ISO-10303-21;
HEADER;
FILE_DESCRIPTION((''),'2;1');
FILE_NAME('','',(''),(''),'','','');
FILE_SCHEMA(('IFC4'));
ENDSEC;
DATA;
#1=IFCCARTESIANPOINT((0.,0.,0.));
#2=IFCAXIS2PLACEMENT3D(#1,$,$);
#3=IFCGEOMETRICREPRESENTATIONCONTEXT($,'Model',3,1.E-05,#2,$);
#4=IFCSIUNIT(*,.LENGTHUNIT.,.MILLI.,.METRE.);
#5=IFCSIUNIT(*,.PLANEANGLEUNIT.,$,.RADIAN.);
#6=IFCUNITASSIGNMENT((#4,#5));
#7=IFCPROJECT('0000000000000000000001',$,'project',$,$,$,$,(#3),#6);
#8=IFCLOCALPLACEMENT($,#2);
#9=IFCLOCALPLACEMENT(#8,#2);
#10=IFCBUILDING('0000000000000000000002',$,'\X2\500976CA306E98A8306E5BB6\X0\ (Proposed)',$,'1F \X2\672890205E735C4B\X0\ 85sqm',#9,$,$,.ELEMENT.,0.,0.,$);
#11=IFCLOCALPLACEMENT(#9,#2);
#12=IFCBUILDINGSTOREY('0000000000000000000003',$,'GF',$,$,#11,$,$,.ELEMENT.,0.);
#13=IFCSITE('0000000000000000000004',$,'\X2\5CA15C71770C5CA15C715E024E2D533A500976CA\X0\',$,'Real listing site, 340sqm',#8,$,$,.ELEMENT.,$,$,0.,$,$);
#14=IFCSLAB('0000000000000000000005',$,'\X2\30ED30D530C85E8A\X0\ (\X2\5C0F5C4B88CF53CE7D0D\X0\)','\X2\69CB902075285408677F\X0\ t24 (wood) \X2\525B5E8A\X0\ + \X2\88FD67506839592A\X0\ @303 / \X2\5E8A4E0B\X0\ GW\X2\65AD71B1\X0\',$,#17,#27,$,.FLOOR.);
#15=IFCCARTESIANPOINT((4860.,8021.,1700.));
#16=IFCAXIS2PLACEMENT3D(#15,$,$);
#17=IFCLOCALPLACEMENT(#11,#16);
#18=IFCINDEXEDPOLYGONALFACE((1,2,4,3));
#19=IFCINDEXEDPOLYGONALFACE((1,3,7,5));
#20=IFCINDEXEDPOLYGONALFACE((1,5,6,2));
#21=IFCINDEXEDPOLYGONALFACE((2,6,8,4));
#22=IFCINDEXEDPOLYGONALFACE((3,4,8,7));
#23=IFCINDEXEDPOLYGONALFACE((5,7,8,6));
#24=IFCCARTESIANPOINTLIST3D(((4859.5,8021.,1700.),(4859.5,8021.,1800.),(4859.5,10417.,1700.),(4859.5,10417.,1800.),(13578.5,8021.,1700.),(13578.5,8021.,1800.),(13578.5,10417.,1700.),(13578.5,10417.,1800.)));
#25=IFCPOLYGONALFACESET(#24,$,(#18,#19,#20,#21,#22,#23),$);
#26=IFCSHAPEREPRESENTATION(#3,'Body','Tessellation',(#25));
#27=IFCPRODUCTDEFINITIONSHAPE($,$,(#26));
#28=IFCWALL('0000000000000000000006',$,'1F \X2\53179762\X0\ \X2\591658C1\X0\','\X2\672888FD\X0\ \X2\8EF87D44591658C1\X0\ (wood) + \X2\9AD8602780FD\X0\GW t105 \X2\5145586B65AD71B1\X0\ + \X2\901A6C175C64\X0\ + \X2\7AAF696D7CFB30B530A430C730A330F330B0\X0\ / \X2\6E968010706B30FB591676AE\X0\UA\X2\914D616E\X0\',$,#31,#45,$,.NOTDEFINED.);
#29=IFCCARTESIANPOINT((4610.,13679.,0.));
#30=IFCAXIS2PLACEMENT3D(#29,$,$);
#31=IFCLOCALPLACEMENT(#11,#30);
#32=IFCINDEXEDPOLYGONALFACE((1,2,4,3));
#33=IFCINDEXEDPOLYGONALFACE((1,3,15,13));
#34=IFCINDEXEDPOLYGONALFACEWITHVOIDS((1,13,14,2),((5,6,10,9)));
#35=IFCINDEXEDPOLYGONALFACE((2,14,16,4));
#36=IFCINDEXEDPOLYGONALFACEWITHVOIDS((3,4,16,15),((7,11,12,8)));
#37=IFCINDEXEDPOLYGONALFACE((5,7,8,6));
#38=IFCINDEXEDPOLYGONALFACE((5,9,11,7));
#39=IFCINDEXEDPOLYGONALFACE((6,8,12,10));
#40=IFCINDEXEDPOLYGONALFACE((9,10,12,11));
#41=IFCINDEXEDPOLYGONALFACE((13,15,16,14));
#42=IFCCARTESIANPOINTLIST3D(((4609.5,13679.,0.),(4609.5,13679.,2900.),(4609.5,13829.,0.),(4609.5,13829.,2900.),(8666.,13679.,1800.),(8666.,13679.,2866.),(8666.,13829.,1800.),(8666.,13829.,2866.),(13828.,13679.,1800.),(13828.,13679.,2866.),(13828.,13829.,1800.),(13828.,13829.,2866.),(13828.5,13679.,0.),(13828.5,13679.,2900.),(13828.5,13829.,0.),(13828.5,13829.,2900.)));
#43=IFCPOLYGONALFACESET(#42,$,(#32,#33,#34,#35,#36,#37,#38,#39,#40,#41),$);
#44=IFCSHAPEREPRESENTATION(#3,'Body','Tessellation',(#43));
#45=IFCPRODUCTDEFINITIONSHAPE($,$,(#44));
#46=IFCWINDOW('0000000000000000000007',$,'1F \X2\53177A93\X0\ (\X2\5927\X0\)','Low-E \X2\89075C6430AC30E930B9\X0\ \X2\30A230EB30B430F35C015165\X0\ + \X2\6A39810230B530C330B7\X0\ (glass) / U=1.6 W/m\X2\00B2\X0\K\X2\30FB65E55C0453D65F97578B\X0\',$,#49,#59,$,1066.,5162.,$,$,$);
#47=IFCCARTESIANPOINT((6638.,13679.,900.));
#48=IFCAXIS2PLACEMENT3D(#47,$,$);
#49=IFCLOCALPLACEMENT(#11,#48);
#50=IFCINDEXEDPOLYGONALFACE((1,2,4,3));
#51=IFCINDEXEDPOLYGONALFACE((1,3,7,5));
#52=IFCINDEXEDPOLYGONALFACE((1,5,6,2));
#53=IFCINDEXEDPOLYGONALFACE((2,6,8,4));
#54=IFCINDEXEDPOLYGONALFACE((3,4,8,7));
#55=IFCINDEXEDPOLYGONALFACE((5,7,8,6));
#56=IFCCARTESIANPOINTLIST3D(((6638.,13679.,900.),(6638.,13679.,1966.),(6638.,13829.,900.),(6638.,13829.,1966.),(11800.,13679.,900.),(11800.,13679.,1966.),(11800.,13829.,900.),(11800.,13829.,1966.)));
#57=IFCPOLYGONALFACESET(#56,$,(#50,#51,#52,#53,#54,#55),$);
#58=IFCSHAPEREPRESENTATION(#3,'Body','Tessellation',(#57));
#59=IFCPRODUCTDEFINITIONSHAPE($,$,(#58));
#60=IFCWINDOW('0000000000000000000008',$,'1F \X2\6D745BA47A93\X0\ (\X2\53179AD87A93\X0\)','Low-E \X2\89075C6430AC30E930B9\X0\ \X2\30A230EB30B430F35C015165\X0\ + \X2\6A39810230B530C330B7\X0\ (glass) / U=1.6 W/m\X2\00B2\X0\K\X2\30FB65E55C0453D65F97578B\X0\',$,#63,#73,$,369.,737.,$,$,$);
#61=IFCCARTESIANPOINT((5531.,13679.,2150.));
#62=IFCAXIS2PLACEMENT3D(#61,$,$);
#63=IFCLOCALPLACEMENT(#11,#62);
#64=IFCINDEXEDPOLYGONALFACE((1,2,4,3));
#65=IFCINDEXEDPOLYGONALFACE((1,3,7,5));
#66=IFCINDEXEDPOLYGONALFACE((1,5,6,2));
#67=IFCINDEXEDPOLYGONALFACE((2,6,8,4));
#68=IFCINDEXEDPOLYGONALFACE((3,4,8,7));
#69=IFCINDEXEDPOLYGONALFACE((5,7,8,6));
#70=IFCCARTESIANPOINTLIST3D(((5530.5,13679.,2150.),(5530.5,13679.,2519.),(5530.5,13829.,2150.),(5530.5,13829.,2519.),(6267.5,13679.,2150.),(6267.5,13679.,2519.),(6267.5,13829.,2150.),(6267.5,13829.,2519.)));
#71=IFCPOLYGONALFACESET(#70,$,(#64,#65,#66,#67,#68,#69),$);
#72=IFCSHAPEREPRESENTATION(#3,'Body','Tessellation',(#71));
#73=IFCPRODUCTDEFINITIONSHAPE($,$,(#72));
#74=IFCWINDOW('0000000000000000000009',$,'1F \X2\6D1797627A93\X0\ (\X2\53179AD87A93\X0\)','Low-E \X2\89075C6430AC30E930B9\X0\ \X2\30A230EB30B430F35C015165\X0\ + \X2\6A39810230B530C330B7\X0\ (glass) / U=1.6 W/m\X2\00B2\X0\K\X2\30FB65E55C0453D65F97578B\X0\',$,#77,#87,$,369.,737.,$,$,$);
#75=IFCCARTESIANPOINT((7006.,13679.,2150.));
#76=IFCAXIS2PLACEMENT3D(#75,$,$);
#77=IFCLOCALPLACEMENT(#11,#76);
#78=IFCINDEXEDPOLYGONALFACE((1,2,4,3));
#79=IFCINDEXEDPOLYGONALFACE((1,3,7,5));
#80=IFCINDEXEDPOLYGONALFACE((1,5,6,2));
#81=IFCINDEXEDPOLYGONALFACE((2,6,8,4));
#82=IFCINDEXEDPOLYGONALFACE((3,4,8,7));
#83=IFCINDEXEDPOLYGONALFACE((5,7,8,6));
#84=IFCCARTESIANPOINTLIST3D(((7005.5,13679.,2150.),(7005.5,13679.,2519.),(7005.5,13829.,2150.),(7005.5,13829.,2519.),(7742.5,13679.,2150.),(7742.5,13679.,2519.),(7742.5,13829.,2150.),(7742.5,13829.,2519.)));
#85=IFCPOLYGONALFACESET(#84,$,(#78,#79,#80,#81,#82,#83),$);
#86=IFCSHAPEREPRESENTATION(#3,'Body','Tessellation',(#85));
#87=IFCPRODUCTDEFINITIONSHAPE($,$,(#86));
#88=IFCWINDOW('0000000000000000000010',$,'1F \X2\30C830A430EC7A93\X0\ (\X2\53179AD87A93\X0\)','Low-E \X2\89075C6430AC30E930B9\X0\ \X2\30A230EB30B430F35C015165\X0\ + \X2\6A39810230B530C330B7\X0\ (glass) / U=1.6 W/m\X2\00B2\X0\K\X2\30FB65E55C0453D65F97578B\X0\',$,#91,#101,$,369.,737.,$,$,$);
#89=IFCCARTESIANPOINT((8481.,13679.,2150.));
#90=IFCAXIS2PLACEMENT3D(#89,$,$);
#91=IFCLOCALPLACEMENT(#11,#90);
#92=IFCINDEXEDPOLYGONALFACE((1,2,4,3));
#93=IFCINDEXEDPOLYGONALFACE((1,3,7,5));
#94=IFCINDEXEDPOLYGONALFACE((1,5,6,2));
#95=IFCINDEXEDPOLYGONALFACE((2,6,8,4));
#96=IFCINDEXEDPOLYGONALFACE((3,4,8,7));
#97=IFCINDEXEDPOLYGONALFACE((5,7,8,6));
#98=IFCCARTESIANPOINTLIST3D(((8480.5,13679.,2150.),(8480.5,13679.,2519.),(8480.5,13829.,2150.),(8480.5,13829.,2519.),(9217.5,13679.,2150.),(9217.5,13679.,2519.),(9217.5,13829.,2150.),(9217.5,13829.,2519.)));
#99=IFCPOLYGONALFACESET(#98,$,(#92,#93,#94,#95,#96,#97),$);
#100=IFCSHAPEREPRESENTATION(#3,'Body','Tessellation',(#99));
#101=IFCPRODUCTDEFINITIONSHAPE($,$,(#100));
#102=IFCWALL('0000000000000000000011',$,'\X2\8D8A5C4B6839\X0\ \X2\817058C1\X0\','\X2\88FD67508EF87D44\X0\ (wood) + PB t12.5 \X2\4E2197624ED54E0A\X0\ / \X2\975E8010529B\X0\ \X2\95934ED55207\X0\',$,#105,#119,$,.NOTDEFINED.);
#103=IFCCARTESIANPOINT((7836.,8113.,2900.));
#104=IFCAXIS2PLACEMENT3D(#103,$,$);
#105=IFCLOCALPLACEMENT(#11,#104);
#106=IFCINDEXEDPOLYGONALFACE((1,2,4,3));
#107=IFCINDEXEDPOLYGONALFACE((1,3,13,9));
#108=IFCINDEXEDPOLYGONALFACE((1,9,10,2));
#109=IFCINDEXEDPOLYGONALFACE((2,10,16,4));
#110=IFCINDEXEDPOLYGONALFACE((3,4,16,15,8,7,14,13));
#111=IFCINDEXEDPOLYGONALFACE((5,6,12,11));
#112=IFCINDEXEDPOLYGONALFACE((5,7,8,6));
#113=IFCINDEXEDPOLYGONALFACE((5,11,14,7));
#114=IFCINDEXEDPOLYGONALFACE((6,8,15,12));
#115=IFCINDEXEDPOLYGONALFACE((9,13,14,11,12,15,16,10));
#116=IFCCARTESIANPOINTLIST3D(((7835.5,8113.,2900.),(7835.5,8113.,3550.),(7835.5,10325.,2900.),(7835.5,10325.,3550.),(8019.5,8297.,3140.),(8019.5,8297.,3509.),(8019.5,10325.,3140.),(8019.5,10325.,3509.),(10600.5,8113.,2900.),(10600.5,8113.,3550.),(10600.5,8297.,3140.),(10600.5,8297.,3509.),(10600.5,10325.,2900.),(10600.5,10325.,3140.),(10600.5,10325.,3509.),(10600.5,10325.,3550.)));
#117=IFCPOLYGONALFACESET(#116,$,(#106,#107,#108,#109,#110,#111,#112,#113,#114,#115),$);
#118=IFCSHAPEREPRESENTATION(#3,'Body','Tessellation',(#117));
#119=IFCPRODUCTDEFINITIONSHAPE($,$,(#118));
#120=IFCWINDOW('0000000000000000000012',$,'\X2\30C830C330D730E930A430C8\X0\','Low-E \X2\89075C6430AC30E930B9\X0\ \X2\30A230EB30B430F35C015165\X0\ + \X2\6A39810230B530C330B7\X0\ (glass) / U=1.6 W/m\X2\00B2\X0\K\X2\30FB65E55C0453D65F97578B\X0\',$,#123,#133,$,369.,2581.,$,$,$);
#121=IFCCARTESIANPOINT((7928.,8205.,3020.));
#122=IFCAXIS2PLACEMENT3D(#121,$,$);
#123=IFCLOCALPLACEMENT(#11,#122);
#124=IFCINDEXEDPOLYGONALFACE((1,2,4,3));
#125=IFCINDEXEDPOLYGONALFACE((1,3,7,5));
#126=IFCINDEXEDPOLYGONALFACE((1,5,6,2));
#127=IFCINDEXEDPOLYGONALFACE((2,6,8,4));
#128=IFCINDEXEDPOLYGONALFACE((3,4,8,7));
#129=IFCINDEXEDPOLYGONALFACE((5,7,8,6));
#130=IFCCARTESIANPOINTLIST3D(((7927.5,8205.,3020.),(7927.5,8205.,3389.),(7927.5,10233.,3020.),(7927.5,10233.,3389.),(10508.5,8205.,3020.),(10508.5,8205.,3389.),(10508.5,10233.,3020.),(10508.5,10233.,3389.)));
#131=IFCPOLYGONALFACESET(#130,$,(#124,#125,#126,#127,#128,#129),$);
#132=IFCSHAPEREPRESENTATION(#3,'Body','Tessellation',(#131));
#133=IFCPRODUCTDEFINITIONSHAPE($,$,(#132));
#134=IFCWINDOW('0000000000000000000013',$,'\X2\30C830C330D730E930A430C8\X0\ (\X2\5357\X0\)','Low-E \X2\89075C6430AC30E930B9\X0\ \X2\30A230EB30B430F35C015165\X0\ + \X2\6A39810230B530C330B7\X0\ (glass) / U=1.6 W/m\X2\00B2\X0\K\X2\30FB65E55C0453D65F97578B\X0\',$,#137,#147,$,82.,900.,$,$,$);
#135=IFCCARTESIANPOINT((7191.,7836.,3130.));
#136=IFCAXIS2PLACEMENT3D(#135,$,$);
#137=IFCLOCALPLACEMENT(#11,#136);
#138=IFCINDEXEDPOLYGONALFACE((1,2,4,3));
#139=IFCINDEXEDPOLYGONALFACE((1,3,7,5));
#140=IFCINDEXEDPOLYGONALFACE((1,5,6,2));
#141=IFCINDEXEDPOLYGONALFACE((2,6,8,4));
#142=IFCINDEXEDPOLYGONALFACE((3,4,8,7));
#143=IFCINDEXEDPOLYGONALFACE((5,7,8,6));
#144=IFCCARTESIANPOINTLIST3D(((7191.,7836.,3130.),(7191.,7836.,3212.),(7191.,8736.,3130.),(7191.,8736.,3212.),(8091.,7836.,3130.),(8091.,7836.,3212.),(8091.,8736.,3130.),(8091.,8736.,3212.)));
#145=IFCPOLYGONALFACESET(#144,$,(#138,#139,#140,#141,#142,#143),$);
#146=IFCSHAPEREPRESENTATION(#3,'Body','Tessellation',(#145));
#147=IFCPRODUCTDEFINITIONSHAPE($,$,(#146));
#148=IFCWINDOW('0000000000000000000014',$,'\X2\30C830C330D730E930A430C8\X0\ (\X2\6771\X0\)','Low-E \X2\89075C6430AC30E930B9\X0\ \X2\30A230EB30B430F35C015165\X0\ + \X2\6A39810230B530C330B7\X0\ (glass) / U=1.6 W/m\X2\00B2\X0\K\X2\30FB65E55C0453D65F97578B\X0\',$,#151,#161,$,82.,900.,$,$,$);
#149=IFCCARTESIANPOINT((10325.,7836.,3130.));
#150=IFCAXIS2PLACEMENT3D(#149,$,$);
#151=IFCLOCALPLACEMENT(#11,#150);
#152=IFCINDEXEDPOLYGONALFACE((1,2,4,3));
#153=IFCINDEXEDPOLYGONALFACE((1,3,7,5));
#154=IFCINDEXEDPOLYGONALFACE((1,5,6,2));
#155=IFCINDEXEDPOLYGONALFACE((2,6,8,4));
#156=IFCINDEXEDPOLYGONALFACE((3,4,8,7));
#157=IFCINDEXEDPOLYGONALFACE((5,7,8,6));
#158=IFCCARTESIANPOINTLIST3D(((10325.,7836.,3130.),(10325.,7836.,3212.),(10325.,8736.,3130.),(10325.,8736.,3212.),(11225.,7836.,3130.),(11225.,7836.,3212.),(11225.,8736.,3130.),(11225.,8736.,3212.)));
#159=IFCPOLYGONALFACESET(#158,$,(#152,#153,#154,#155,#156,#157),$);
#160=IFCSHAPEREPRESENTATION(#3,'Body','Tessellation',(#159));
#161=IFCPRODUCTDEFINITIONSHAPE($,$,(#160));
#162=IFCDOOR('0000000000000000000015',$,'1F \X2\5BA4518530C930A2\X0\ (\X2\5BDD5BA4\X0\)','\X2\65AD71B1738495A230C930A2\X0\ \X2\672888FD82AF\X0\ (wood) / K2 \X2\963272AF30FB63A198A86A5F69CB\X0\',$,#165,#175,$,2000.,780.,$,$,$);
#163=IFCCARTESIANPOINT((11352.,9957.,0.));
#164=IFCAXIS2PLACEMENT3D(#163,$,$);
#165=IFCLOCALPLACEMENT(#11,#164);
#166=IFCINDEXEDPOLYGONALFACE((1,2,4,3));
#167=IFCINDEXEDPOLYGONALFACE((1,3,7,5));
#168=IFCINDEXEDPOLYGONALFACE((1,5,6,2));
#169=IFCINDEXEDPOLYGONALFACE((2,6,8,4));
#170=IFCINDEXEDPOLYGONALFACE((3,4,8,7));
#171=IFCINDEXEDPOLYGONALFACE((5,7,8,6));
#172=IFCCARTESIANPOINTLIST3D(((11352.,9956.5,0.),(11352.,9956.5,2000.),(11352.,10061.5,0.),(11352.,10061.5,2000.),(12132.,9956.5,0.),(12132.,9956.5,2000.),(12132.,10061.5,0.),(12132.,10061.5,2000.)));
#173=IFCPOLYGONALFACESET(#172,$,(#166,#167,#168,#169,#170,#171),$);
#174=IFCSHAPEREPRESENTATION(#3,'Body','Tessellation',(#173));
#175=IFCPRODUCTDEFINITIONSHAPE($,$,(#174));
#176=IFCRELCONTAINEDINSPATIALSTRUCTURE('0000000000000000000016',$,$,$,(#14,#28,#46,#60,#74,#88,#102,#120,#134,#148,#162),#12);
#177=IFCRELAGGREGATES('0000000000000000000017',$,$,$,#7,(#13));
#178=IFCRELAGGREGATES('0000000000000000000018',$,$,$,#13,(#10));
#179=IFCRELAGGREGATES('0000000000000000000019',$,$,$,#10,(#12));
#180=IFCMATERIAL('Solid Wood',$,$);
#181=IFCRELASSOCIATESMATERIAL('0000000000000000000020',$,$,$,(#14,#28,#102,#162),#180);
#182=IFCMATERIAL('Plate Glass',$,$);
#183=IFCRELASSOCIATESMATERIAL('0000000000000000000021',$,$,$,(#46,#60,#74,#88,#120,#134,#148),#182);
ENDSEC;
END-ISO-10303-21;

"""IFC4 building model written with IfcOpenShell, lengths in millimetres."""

from ifc_helpers import new_model, si_unit, frame, frame_2d, origin, place, context, project, spatial, rectangle, extrude, material, element, fill, save


model = new_model("IFC4")

# Units and contexts
model_context = context("Model", 3, precision=1e-05, world=origin())
ifc_project = project(units=[si_unit("LENGTHUNIT", "METRE", prefix="MILLI"), si_unit("PLANEANGLEUNIT", "RADIAN")], contexts=[model_context])

# Site, building, storey
site_placement = place(None, origin())
site = spatial("IfcSite", under=ifc_project, at=site_placement, Name="岡山県岡山市中区倉益", ObjectType="Real listing site, 340sqm", CompositionType="ELEMENT", RefElevation=0.0)
building_placement = place(site_placement, origin())
building = spatial("IfcBuilding", under=site, at=building_placement, Name="倉益の風の家 (Proposed)", ObjectType="1F 木造平屋 85sqm", CompositionType="ELEMENT", ElevationOfRefHeight=0.0, ElevationOfTerrain=0.0)
storey_placement = place(building_placement, origin())
storey = spatial("IfcBuildingStorey", under=building, at=storey_placement, Name="GF", CompositionType="ELEMENT", Elevation=0.0)

# Slab
ifc_material_1 = material(Name="Solid Wood")
slab_placement = place(storey_placement, frame((4860.0, 8021.0, 1700.0)))
element("IfcSlab", 1, at=slab_placement, inside=storey, material=ifc_material_1, Name="ロフト床 (小屋裏収納)", Description="構造用合板 t24 (wood) 剛床 + 製材根太 @303 / 床下 GW断熱", PredefinedType="FLOOR", context=model_context, shape_type="SweptSolid", body=[
    extrude(rectangle(XDim=8719.0, YDim=2396.0, at=frame_2d((4359.0, 1198.0))), frame((4860.0, 8021.0, 1700.0)), (0.0, 0.0, 1.0), 100.0),
])

# Wall, openings, windows
wall_1_placement = place(storey_placement, frame((4610.0, 13679.0, 0.0)))
wall_1 = element("IfcWall", 2, at=wall_1_placement, inside=storey, material=ifc_material_1, Name="1F 北面 外壁", Description="木製 軸組外壁 (wood) + 高性能GW t105 充填断熱 + 通気層 + 窯業系サイディング / 準耐火・外皮UA配慮", PredefinedType="NOTDEFINED", context=model_context, shape_type="SweptSolid", body=[
    extrude(rectangle(XDim=9219.0, YDim=150.0, at=frame_2d((4609.0, 75.0))), frame((4610.0, 13679.0, 0.0)), (0.0, 0.0, 1.0), 2900.0),
])
opening_1_placement = place(storey_placement, frame((6638.0, 13679.0, 900.0)))
opening_1 = element("IfcOpeningElement", 3, at=opening_1_placement, cuts=wall_1, PredefinedType="NOTDEFINED", context=model_context, shape_type="SweptSolid", body=[
    extrude(rectangle(XDim=5162.0, YDim=150.0, at=frame_2d((2581.0, 75.0))), frame((6638.0, 13679.0, 900.0)), (0.0, 0.0, 1.0), 1066.0),
])
opening_2_placement = place(storey_placement, frame((5531.0, 13679.0, 2150.0)))
opening_2 = element("IfcOpeningElement", 4, at=opening_2_placement, cuts=wall_1, PredefinedType="NOTDEFINED", context=model_context, shape_type="SweptSolid", body=[
    extrude(rectangle(XDim=737.0, YDim=150.0, at=frame_2d((368.0, 75.0))), frame((5531.0, 13679.0, 2150.0)), (0.0, 0.0, 1.0), 369.0),
])
opening_3_placement = place(storey_placement, frame((7006.0, 13679.0, 2150.0)))
opening_3 = element("IfcOpeningElement", 5, at=opening_3_placement, cuts=wall_1, PredefinedType="NOTDEFINED", context=model_context, shape_type="SweptSolid", body=[
    extrude(rectangle(XDim=737.0, YDim=150.0, at=frame_2d((368.0, 75.0))), frame((7006.0, 13679.0, 2150.0)), (0.0, 0.0, 1.0), 369.0),
])
opening_4_placement = place(storey_placement, frame((8481.0, 13679.0, 2150.0)))
opening_4 = element("IfcOpeningElement", 6, at=opening_4_placement, cuts=wall_1, PredefinedType="NOTDEFINED", context=model_context, shape_type="SweptSolid", body=[
    extrude(rectangle(XDim=737.0, YDim=150.0, at=frame_2d((368.0, 75.0))), frame((8481.0, 13679.0, 2150.0)), (0.0, 0.0, 1.0), 369.0),
])
ifc_material_2 = material(Name="Plate Glass")
window_1_placement = place(storey_placement, frame((6638.0, 13679.0, 900.0)))
window_1 = element("IfcWindow", 7, at=window_1_placement, inside=storey, material=ifc_material_2, Name="1F 北窓 (大)", Description="Low-E 複層ガラス アルゴン封入 + 樹脂サッシ (glass) / U=1.6 W/m²K・日射取得型", OverallHeight=1066.0, OverallWidth=5162.0, context=model_context, shape_type="SweptSolid", body=[
    extrude(rectangle(XDim=5162.0, YDim=150.0, at=frame_2d((2581.0, 75.0))), frame((6638.0, 13679.0, 900.0)), (0.0, 0.0, 1.0), 1066.0),
])
fill(opening_1, window_1)
window_2_placement = place(storey_placement, frame((5531.0, 13679.0, 2150.0)))
window_2 = element("IfcWindow", 8, at=window_2_placement, inside=storey, material=ifc_material_2, Name="1F 浴室窓 (北高窓)", Description="Low-E 複層ガラス アルゴン封入 + 樹脂サッシ (glass) / U=1.6 W/m²K・日射取得型", OverallHeight=369.0, OverallWidth=737.0, context=model_context, shape_type="SweptSolid", body=[
    extrude(rectangle(XDim=737.0, YDim=150.0, at=frame_2d((368.0, 75.0))), frame((5531.0, 13679.0, 2150.0)), (0.0, 0.0, 1.0), 369.0),
])
fill(opening_2, window_2)
window_3_placement = place(storey_placement, frame((7006.0, 13679.0, 2150.0)))
window_3 = element("IfcWindow", 9, at=window_3_placement, inside=storey, material=ifc_material_2, Name="1F 洗面窓 (北高窓)", Description="Low-E 複層ガラス アルゴン封入 + 樹脂サッシ (glass) / U=1.6 W/m²K・日射取得型", OverallHeight=369.0, OverallWidth=737.0, context=model_context, shape_type="SweptSolid", body=[
    extrude(rectangle(XDim=737.0, YDim=150.0, at=frame_2d((368.0, 75.0))), frame((7006.0, 13679.0, 2150.0)), (0.0, 0.0, 1.0), 369.0),
])
fill(opening_3, window_3)
window_4_placement = place(storey_placement, frame((8481.0, 13679.0, 2150.0)))
window_4 = element("IfcWindow", 10, at=window_4_placement, inside=storey, material=ifc_material_2, Name="1F トイレ窓 (北高窓)", Description="Low-E 複層ガラス アルゴン封入 + 樹脂サッシ (glass) / U=1.6 W/m²K・日射取得型", OverallHeight=369.0, OverallWidth=737.0, context=model_context, shape_type="SweptSolid", body=[
    extrude(rectangle(XDim=737.0, YDim=150.0, at=frame_2d((368.0, 75.0))), frame((8481.0, 13679.0, 2150.0)), (0.0, 0.0, 1.0), 369.0),
])
fill(opening_4, window_4)

# Wall, openings, windows
wall_2_placement = place(storey_placement, frame((7836.0, 8113.0, 2900.0)))
wall_2 = element("IfcWall", 11, at=wall_2_placement, inside=storey, material=ifc_material_1, Name="越屋根 腰壁", Description="製材軸組 (wood) + PB t12.5 両面仕上 / 非耐力 間仕切", PredefinedType="NOTDEFINED", context=model_context, shape_type="SweptSolid", body=[
    extrude(rectangle(XDim=2765.0, YDim=2212.0, at=frame_2d((1382.0, 1106.0))), frame((7836.0, 8113.0, 2900.0)), (0.0, 0.0, 1.0), 650.0),
])
opening_5_placement = place(storey_placement, frame((7928.0, 8205.0, 3020.0)))
opening_5 = element("IfcOpeningElement", 12, at=opening_5_placement, cuts=wall_2, PredefinedType="NOTDEFINED", context=model_context, shape_type="SweptSolid", body=[
    extrude(rectangle(XDim=2581.0, YDim=2028.0, at=frame_2d((1290.0, 1014.0))), frame((7928.0, 8205.0, 3020.0)), (0.0, 0.0, 1.0), 369.0),
])
opening_6_placement = place(storey_placement, frame((7191.0, 7836.0, 3130.0)))
opening_6 = element("IfcOpeningElement", 13, at=opening_6_placement, cuts=wall_2, PredefinedType="NOTDEFINED", context=model_context, shape_type="SweptSolid", body=[
    extrude(rectangle(XDim=900.0, YDim=900.0, at=frame_2d((450.0, 450.0))), frame((7191.0, 7836.0, 3130.0)), (0.0, 0.0, 1.0), 82.0),
])
opening_7_placement = place(storey_placement, frame((10325.0, 7836.0, 3130.0)))
opening_7 = element("IfcOpeningElement", 14, at=opening_7_placement, cuts=wall_2, PredefinedType="NOTDEFINED", context=model_context, shape_type="SweptSolid", body=[
    extrude(rectangle(XDim=900.0, YDim=900.0, at=frame_2d((450.0, 450.0))), frame((10325.0, 7836.0, 3130.0)), (0.0, 0.0, 1.0), 82.0),
])
window_5_placement = place(storey_placement, frame((7928.0, 8205.0, 3020.0)))
window_5 = element("IfcWindow", 15, at=window_5_placement, inside=storey, material=ifc_material_2, Name="トップライト", Description="Low-E 複層ガラス アルゴン封入 + 樹脂サッシ (glass) / U=1.6 W/m²K・日射取得型", OverallHeight=369.0, OverallWidth=2581.0, context=model_context, shape_type="SweptSolid", body=[
    extrude(rectangle(XDim=2581.0, YDim=2028.0, at=frame_2d((1290.0, 1014.0))), frame((7928.0, 8205.0, 3020.0)), (0.0, 0.0, 1.0), 369.0),
])
fill(opening_5, window_5)
window_6_placement = place(storey_placement, frame((7191.0, 7836.0, 3130.0)))
window_6 = element("IfcWindow", 16, at=window_6_placement, inside=storey, material=ifc_material_2, Name="トップライト (南)", Description="Low-E 複層ガラス アルゴン封入 + 樹脂サッシ (glass) / U=1.6 W/m²K・日射取得型", OverallHeight=82.0, OverallWidth=900.0, context=model_context, shape_type="SweptSolid", body=[
    extrude(rectangle(XDim=900.0, YDim=900.0, at=frame_2d((450.0, 450.0))), frame((7191.0, 7836.0, 3130.0)), (0.0, 0.0, 1.0), 82.0),
])
fill(opening_6, window_6)
window_7_placement = place(storey_placement, frame((10325.0, 7836.0, 3130.0)))
window_7 = element("IfcWindow", 17, at=window_7_placement, inside=storey, material=ifc_material_2, Name="トップライト (東)", Description="Low-E 複層ガラス アルゴン封入 + 樹脂サッシ (glass) / U=1.6 W/m²K・日射取得型", OverallHeight=82.0, OverallWidth=900.0, context=model_context, shape_type="SweptSolid", body=[
    extrude(rectangle(XDim=900.0, YDim=900.0, at=frame_2d((450.0, 450.0))), frame((10325.0, 7836.0, 3130.0)), (0.0, 0.0, 1.0), 82.0),
])
fill(opening_7, window_7)

# Door
door_1_placement = place(storey_placement, frame((11352.0, 9957.0, 0.0)))
element("IfcDoor", 18, at=door_1_placement, inside=storey, material=ifc_material_1, Name="1F 室内ドア (寝室)", Description="断熱玄関ドア 木製芯 (wood) / K2 防犯・採風機構", OverallHeight=2000.0, OverallWidth=780.0, context=model_context, shape_type="SweptSolid", body=[
    extrude(rectangle(XDim=780.0, YDim=105.0, at=frame_2d((390.0, 52.0))), frame((11352.0, 9957.0, 0.0)), (0.0, 0.0, 1.0), 2000.0),
])

save(model, "model.ifc")
